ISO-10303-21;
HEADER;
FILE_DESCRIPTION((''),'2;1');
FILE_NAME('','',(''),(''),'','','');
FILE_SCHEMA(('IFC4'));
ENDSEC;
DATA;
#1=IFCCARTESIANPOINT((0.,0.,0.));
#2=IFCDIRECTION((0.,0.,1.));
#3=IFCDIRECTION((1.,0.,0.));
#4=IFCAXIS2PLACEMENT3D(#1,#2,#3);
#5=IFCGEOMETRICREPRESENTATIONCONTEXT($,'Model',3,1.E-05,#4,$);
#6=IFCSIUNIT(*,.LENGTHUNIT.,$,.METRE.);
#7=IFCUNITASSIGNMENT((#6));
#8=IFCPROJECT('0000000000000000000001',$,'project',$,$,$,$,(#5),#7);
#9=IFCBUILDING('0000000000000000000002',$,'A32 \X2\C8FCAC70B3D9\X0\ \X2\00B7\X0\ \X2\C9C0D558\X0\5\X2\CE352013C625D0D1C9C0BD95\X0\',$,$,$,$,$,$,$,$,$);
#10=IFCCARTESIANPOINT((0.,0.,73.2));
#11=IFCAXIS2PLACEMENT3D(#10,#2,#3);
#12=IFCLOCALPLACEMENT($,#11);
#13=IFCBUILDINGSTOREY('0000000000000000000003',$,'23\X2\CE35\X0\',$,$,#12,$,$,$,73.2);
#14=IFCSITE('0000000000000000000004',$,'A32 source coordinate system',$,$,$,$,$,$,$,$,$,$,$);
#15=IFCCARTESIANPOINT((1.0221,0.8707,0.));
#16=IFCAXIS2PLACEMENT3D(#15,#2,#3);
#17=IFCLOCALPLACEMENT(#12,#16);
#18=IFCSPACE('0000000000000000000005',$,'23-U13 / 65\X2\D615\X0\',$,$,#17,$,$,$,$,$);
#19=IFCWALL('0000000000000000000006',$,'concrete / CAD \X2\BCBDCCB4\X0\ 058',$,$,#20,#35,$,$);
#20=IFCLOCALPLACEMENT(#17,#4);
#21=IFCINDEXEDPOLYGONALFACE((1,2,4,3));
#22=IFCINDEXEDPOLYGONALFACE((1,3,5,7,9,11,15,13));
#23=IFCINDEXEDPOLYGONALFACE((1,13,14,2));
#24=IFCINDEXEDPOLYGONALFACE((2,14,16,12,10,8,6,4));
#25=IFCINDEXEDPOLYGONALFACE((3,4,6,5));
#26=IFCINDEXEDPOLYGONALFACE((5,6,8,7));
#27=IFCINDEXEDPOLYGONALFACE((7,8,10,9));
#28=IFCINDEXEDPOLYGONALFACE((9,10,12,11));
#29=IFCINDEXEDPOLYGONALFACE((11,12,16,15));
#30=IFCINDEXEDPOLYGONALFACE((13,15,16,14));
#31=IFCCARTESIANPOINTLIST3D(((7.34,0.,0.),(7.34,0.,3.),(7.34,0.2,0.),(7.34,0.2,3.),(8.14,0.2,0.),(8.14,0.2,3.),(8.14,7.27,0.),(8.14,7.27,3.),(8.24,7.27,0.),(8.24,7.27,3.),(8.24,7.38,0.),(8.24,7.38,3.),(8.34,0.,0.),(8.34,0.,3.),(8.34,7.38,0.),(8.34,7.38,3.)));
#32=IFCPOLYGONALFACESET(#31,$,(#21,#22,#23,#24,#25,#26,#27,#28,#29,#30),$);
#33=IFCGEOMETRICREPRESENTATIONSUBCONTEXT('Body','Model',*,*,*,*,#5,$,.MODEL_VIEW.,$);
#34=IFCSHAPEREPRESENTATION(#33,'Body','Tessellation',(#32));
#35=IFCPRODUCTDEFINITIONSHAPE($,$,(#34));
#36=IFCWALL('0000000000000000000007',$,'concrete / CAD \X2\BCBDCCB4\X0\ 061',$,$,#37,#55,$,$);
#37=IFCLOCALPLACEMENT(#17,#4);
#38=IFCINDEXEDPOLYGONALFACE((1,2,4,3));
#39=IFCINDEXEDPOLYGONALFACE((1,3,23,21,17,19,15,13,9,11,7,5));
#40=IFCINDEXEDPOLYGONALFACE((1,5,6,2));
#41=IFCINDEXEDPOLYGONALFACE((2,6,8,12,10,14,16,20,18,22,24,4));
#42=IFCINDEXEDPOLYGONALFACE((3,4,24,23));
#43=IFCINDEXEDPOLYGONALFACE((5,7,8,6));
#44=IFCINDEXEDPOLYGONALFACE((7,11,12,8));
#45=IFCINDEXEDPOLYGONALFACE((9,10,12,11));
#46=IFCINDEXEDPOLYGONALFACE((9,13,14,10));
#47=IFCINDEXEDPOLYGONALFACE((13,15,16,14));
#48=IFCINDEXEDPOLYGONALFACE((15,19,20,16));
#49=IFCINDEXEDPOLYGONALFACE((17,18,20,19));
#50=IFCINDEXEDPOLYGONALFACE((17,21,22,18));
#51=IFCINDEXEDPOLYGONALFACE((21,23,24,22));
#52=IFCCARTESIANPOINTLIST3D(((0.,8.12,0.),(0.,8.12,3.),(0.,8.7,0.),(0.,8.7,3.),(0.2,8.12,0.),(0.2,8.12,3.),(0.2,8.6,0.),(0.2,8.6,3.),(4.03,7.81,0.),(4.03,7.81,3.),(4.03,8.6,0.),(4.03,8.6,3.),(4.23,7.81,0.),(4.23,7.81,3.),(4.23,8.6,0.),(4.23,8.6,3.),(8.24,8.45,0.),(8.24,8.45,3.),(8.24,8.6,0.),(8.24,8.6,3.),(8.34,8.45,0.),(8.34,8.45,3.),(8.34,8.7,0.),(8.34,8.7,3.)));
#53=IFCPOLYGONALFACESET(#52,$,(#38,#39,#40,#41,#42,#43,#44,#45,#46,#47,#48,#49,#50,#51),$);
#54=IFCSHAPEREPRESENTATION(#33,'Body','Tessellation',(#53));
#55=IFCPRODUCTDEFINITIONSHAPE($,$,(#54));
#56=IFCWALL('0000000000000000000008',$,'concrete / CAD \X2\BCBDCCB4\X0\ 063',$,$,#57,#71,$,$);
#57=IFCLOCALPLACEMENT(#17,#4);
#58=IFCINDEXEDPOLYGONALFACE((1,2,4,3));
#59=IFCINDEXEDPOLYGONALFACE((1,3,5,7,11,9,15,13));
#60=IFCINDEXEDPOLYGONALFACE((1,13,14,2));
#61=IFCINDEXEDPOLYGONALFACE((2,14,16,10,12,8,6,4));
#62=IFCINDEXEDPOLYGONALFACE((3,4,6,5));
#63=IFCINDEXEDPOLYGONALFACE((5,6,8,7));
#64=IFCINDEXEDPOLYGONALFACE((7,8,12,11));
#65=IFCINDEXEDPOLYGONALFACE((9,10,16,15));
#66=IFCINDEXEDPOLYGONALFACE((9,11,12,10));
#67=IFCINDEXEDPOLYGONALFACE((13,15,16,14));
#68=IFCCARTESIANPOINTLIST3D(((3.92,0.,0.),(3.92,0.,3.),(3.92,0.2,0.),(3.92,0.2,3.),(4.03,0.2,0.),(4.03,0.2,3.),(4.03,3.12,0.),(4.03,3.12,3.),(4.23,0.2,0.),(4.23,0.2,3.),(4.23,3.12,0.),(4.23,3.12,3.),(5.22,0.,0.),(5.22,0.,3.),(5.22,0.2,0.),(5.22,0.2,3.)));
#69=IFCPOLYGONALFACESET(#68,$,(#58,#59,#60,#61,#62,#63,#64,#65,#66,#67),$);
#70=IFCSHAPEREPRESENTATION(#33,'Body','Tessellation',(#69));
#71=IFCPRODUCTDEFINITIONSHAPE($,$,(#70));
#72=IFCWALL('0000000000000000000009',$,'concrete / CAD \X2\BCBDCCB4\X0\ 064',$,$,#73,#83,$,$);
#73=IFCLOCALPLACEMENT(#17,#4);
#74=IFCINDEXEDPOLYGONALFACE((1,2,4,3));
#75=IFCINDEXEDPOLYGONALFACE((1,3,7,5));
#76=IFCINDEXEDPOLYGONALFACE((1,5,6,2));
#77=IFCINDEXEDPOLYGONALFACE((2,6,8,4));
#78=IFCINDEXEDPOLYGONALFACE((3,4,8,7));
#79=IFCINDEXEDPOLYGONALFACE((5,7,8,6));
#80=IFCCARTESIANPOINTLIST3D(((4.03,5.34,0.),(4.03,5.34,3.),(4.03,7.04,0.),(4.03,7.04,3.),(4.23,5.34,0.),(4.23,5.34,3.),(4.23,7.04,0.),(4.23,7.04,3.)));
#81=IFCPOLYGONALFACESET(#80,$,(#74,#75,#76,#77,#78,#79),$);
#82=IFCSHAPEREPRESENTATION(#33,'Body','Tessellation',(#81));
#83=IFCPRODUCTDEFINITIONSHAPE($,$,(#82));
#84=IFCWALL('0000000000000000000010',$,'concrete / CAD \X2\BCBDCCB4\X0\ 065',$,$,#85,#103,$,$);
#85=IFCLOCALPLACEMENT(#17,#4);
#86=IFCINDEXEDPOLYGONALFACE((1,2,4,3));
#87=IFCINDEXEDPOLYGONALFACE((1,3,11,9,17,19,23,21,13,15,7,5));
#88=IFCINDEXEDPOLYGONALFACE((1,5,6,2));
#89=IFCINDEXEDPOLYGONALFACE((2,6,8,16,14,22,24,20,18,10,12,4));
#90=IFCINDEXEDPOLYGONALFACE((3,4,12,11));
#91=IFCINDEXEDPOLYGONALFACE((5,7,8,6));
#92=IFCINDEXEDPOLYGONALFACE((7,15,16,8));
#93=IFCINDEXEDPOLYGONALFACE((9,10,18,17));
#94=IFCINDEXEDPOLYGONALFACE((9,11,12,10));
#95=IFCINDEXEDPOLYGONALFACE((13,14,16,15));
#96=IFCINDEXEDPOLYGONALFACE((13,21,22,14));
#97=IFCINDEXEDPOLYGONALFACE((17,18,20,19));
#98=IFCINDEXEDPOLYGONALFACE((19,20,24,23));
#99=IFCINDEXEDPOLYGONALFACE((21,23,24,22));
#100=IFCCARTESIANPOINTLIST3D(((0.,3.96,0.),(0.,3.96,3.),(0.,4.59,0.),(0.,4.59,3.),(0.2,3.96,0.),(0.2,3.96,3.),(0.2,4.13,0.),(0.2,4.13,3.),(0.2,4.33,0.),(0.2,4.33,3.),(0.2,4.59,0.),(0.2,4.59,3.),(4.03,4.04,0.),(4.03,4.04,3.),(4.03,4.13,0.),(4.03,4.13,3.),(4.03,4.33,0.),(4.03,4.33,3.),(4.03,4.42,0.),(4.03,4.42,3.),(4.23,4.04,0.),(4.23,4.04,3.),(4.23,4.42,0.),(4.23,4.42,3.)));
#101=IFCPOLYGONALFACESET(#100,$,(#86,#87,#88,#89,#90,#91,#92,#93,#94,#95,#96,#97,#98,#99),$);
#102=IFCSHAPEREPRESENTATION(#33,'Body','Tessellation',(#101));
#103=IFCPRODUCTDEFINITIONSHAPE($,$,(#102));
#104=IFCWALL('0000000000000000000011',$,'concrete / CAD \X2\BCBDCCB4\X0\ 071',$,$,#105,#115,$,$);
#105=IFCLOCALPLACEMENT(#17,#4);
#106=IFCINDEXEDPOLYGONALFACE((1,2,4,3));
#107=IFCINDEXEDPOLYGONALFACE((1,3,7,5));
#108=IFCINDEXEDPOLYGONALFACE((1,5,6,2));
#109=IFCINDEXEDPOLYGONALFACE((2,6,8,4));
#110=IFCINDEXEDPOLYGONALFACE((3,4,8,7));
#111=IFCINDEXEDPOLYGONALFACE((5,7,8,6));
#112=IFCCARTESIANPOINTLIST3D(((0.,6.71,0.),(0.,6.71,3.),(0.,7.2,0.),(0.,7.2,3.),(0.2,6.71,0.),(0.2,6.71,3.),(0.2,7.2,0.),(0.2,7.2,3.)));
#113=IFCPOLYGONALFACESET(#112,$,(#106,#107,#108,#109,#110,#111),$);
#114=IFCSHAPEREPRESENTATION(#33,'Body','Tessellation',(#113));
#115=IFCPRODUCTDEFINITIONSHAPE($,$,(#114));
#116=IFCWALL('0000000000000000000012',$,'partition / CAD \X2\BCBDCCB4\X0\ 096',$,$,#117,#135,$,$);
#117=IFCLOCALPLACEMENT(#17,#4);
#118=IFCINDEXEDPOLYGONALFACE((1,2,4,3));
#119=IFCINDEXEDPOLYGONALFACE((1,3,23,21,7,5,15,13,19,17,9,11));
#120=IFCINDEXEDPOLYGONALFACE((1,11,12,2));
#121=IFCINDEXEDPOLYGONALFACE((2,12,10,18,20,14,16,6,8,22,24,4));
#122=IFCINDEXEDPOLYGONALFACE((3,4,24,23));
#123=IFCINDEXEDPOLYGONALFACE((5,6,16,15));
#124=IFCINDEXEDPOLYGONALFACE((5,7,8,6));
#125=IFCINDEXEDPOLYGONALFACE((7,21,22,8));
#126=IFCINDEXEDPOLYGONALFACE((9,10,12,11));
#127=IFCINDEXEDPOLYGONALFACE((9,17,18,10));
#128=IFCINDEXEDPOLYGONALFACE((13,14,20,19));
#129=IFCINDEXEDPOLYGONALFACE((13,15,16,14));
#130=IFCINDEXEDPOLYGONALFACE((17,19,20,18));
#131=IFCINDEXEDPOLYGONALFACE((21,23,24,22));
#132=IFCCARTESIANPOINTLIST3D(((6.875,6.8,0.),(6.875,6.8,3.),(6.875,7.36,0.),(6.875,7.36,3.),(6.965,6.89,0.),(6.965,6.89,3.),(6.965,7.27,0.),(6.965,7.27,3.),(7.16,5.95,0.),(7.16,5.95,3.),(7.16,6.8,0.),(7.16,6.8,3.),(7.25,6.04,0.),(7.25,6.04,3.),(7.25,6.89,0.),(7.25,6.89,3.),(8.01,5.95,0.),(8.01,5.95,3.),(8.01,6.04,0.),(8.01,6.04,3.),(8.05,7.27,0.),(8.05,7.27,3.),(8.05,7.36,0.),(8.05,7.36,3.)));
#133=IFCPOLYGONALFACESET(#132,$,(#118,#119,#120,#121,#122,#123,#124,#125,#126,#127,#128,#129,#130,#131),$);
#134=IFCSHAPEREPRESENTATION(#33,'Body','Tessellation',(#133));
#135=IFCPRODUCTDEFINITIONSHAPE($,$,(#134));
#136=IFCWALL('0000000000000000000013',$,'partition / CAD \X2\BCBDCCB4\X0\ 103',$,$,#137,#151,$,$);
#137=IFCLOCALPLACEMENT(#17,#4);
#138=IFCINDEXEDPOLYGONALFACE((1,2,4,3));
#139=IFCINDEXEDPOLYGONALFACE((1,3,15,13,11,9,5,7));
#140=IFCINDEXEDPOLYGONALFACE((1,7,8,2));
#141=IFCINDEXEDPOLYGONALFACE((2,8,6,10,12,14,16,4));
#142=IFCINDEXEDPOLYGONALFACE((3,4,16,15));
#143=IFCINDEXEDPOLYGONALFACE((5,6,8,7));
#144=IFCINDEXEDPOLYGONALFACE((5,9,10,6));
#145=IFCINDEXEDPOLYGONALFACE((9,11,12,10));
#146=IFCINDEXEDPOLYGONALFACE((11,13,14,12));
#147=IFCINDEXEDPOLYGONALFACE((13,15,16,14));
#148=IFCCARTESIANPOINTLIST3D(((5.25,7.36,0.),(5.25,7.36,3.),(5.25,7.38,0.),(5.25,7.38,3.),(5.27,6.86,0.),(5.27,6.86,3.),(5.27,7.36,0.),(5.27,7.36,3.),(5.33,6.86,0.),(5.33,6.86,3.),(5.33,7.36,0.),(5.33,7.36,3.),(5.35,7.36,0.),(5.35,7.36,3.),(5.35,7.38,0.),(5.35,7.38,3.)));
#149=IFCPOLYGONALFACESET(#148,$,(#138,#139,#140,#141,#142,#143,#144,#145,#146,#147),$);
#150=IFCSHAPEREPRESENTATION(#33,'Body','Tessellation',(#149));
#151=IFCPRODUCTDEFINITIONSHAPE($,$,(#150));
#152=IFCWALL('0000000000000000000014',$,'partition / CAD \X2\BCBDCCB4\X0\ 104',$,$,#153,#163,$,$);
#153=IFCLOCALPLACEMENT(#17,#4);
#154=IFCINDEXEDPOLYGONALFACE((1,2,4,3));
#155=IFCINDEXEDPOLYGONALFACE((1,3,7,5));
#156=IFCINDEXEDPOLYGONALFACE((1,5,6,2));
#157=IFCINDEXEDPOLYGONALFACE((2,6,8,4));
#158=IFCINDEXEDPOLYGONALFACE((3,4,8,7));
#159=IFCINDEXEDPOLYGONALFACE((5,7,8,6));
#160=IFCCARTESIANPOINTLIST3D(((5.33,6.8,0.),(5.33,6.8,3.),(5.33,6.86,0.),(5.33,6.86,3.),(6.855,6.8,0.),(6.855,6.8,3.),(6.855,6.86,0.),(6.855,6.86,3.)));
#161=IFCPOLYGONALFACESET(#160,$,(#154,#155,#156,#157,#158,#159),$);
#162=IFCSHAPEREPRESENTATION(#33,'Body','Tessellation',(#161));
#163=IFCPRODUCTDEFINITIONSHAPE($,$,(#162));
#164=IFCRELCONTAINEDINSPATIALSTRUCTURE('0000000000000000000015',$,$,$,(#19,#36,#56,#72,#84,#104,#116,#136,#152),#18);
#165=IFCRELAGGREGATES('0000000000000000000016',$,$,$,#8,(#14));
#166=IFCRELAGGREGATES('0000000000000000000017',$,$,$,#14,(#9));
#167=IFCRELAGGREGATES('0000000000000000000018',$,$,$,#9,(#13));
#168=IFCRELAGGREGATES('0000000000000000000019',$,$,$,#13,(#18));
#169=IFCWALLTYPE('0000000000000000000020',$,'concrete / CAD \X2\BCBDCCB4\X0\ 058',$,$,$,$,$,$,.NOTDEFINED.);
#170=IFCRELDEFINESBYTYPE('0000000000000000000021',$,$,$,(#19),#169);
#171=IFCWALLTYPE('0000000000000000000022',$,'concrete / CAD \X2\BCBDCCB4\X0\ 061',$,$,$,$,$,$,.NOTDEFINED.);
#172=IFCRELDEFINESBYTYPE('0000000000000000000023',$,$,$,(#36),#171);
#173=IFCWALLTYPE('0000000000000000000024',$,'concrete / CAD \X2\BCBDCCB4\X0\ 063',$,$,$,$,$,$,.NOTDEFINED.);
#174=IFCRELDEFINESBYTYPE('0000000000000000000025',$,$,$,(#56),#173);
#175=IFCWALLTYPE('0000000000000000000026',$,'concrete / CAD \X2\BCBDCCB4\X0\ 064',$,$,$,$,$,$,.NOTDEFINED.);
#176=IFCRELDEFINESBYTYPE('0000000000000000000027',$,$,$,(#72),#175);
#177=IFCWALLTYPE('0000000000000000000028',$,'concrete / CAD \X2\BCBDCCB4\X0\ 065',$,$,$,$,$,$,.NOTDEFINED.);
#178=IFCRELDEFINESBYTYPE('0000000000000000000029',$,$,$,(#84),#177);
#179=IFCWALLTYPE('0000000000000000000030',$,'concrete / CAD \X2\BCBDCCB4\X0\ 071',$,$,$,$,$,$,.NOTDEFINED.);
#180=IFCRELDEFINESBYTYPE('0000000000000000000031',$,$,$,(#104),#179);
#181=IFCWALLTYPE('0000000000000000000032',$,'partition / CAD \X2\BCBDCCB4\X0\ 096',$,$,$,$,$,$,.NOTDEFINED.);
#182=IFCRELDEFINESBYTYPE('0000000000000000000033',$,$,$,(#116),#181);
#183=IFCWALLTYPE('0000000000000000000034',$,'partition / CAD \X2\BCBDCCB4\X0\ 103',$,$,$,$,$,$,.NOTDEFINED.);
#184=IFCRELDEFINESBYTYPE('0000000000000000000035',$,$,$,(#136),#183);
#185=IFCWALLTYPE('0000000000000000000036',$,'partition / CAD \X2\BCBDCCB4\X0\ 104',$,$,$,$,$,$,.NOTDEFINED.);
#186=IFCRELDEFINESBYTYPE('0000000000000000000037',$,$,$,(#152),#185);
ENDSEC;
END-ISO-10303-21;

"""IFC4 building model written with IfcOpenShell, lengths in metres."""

from ifc_helpers import new_model, si_unit, frame, origin, origin_with_axes, place, context, subcontext, project, spatial, polyline, outline, extrude, source, transform, mapped, type_object, type_shapes, element, save


model = new_model("IFC4")

# Units and contexts
model_context = context("Model", 3, precision=1e-05, world=origin_with_axes())
body_context = subcontext(model_context, "Body", "Model", "MODEL_VIEW")
ifc_project = project(units=[si_unit("LENGTHUNIT", "METRE")], contexts=[model_context])

# Site, building, storey, space
site = spatial("IfcSite", under=ifc_project, Name="A32 source coordinate system")
building = spatial("IfcBuilding", under=site, Name="A32 주거동 · 지하5층–옥탑지붕")
storey_placement = place(None, frame((0.0, 0.0, 73.2), z_axis=(0.0, 0.0, 1.0), x_axis=(1.0, 0.0, 0.0)))
storey = spatial("IfcBuildingStorey", under=building, at=storey_placement, Name="23층", Elevation=73.2)
space_placement = place(storey_placement, frame((1.0221, 0.8707, 0.0), z_axis=(0.0, 0.0, 1.0), x_axis=(1.0, 0.0, 0.0)))
space = spatial("IfcSpace", under=storey, at=space_placement, Name="23-U13 / 65형")

# Walls
wall_type_1 = type_object("IfcWallType", Name="concrete / CAD 벽체 058", PredefinedType="NOTDEFINED")
shared_shape_1 = source(origin(), body_context, "Body", "SweptSolid", [
    extrude(outline(polyline([(8.34, 0.0), (7.34, 0.0), (7.34, 0.2), (8.14, 0.2), (8.14, 7.27), (8.24, 7.27), (8.24, 7.38), (8.34, 7.38), (8.34, 0.0)])), origin(), (0.0, 0.0, 1.0), 3.0),
])
type_shapes(wall_type_1, [shared_shape_1])
wall_1_placement = place(space_placement, origin_with_axes())
element("IfcWall", 1, at=wall_1_placement, inside=space, type_object=wall_type_1, Name="concrete / CAD 벽체 058", context=body_context, shape_type="MappedRepresentation", body=[
    mapped(shared_shape_1, transform((0.0, 0.0, 0.0), scale=1.0)),
])
wall_type_2 = type_object("IfcWallType", Name="concrete / CAD 벽체 061", PredefinedType="NOTDEFINED")
shared_shape_2 = source(origin(), body_context, "Body", "SweptSolid", [
    extrude(outline(polyline([(0.2, 8.6), (0.2, 8.12), (0.0, 8.12), (0.0, 8.7), (8.34, 8.7), (8.34, 8.45), (8.24, 8.45), (8.24, 8.6), (4.23, 8.6), (4.23, 7.81), (4.03, 7.81), (4.03, 8.6), (0.2, 8.6)])), origin(), (0.0, 0.0, 1.0), 3.0),
])
type_shapes(wall_type_2, [shared_shape_2])
wall_2_placement = place(space_placement, origin_with_axes())
element("IfcWall", 2, at=wall_2_placement, inside=space, type_object=wall_type_2, Name="concrete / CAD 벽체 061", context=body_context, shape_type="MappedRepresentation", body=[
    mapped(shared_shape_2, transform((0.0, 0.0, 0.0), scale=1.0)),
])
wall_type_3 = type_object("IfcWallType", Name="concrete / CAD 벽체 063", PredefinedType="NOTDEFINED")
shared_shape_3 = source(origin(), body_context, "Body", "SweptSolid", [
    extrude(outline(polyline([(5.22, 0.0), (3.92, 0.0), (3.92, 0.2), (4.03, 0.2), (4.03, 3.12), (4.23, 3.12), (4.23, 0.2), (5.22, 0.2), (5.22, 0.0)])), origin(), (0.0, 0.0, 1.0), 3.0),
])
type_shapes(wall_type_3, [shared_shape_3])
wall_3_placement = place(space_placement, origin_with_axes())
element("IfcWall", 3, at=wall_3_placement, inside=space, type_object=wall_type_3, Name="concrete / CAD 벽체 063", context=body_context, shape_type="MappedRepresentation", body=[
    mapped(shared_shape_3, transform((0.0, 0.0, 0.0), scale=1.0)),
])
wall_type_4 = type_object("IfcWallType", Name="concrete / CAD 벽체 064", PredefinedType="NOTDEFINED")
shared_shape_4 = source(origin(), body_context, "Body", "SweptSolid", [
    extrude(outline(polyline([(4.03, 7.04), (4.23, 7.04), (4.23, 5.34), (4.03, 5.34), (4.03, 7.04)])), origin(), (0.0, 0.0, 1.0), 3.0),
])
type_shapes(wall_type_4, [shared_shape_4])
wall_4_placement = place(space_placement, origin_with_axes())
element("IfcWall", 4, at=wall_4_placement, inside=space, type_object=wall_type_4, Name="concrete / CAD 벽체 064", context=body_context, shape_type="MappedRepresentation", body=[
    mapped(shared_shape_4, transform((0.0, 0.0, 0.0), scale=1.0)),
])
wall_type_5 = type_object("IfcWallType", Name="concrete / CAD 벽체 065", PredefinedType="NOTDEFINED")
shared_shape_5 = source(origin(), body_context, "Body", "SweptSolid", [
    extrude(outline(polyline([(0.2, 4.59), (0.2, 4.33), (4.03, 4.33), (4.03, 4.42), (4.23, 4.42), (4.23, 4.04), (4.03, 4.04), (4.03, 4.13), (0.2, 4.13), (0.2, 3.96), (0.0, 3.96), (0.0, 4.59), (0.2, 4.59)])), origin(), (0.0, 0.0, 1.0), 3.0),
])
type_shapes(wall_type_5, [shared_shape_5])
wall_5_placement = place(space_placement, origin_with_axes())
element("IfcWall", 5, at=wall_5_placement, inside=space, type_object=wall_type_5, Name="concrete / CAD 벽체 065", context=body_context, shape_type="MappedRepresentation", body=[
    mapped(shared_shape_5, transform((0.0, 0.0, 0.0), scale=1.0)),
])
wall_type_6 = type_object("IfcWallType", Name="concrete / CAD 벽체 071", PredefinedType="NOTDEFINED")
shared_shape_6 = source(origin(), body_context, "Body", "SweptSolid", [
    extrude(outline(polyline([(0.2, 6.71), (0.0, 6.71), (0.0, 7.2), (0.2, 7.2), (0.2, 6.71)])), origin(), (0.0, 0.0, 1.0), 3.0),
])
type_shapes(wall_type_6, [shared_shape_6])
wall_6_placement = place(space_placement, origin_with_axes())
element("IfcWall", 6, at=wall_6_placement, inside=space, type_object=wall_type_6, Name="concrete / CAD 벽체 071", context=body_context, shape_type="MappedRepresentation", body=[
    mapped(shared_shape_6, transform((0.0, 0.0, 0.0), scale=1.0)),
])
wall_type_7 = type_object("IfcWallType", Name="partition / CAD 벽체 096", PredefinedType="NOTDEFINED")
shared_shape_7 = source(origin(), body_context, "Body", "SweptSolid", [
    extrude(outline(polyline([(7.25, 6.04), (8.01, 6.04), (8.01, 5.95), (7.16, 5.95), (7.16, 6.8), (6.875, 6.8), (6.875, 7.36), (8.05, 7.36), (8.05, 7.27), (6.965, 7.27), (6.965, 6.89), (7.25, 6.89), (7.25, 6.04)])), origin(), (0.0, 0.0, 1.0), 3.0),
])
type_shapes(wall_type_7, [shared_shape_7])
wall_7_placement = place(space_placement, origin_with_axes())
element("IfcWall", 7, at=wall_7_placement, inside=space, type_object=wall_type_7, Name="partition / CAD 벽체 096", context=body_context, shape_type="MappedRepresentation", body=[
    mapped(shared_shape_7, transform((0.0, 0.0, 0.0), scale=1.0)),
])
wall_type_8 = type_object("IfcWallType", Name="partition / CAD 벽체 103", PredefinedType="NOTDEFINED")
shared_shape_8 = source(origin(), body_context, "Body", "SweptSolid", [
    extrude(outline(polyline([(5.27, 7.36), (5.25, 7.36), (5.25, 7.38), (5.35, 7.38), (5.35, 7.36), (5.33, 7.36), (5.33, 6.86), (5.27, 6.86), (5.27, 7.36)])), origin(), (0.0, 0.0, 1.0), 3.0),
])
type_shapes(wall_type_8, [shared_shape_8])
wall_8_placement = place(space_placement, origin_with_axes())
element("IfcWall", 8, at=wall_8_placement, inside=space, type_object=wall_type_8, Name="partition / CAD 벽체 103", context=body_context, shape_type="MappedRepresentation", body=[
    mapped(shared_shape_8, transform((0.0, 0.0, 0.0), scale=1.0)),
])
wall_type_9 = type_object("IfcWallType", Name="partition / CAD 벽체 104", PredefinedType="NOTDEFINED")
shared_shape_9 = source(origin(), body_context, "Body", "SweptSolid", [
    extrude(outline(polyline([(6.855, 6.86), (6.855, 6.8), (5.33, 6.8), (5.33, 6.86), (6.855, 6.86)])), origin(), (0.0, 0.0, 1.0), 3.0),
])
type_shapes(wall_type_9, [shared_shape_9])
wall_9_placement = place(space_placement, origin_with_axes())
element("IfcWall", 9, at=wall_9_placement, inside=space, type_object=wall_type_9, Name="partition / CAD 벽체 104", context=body_context, shape_type="MappedRepresentation", body=[
    mapped(shared_shape_9, transform((0.0, 0.0, 0.0), scale=1.0)),
])

save(model, "model.ifc")
